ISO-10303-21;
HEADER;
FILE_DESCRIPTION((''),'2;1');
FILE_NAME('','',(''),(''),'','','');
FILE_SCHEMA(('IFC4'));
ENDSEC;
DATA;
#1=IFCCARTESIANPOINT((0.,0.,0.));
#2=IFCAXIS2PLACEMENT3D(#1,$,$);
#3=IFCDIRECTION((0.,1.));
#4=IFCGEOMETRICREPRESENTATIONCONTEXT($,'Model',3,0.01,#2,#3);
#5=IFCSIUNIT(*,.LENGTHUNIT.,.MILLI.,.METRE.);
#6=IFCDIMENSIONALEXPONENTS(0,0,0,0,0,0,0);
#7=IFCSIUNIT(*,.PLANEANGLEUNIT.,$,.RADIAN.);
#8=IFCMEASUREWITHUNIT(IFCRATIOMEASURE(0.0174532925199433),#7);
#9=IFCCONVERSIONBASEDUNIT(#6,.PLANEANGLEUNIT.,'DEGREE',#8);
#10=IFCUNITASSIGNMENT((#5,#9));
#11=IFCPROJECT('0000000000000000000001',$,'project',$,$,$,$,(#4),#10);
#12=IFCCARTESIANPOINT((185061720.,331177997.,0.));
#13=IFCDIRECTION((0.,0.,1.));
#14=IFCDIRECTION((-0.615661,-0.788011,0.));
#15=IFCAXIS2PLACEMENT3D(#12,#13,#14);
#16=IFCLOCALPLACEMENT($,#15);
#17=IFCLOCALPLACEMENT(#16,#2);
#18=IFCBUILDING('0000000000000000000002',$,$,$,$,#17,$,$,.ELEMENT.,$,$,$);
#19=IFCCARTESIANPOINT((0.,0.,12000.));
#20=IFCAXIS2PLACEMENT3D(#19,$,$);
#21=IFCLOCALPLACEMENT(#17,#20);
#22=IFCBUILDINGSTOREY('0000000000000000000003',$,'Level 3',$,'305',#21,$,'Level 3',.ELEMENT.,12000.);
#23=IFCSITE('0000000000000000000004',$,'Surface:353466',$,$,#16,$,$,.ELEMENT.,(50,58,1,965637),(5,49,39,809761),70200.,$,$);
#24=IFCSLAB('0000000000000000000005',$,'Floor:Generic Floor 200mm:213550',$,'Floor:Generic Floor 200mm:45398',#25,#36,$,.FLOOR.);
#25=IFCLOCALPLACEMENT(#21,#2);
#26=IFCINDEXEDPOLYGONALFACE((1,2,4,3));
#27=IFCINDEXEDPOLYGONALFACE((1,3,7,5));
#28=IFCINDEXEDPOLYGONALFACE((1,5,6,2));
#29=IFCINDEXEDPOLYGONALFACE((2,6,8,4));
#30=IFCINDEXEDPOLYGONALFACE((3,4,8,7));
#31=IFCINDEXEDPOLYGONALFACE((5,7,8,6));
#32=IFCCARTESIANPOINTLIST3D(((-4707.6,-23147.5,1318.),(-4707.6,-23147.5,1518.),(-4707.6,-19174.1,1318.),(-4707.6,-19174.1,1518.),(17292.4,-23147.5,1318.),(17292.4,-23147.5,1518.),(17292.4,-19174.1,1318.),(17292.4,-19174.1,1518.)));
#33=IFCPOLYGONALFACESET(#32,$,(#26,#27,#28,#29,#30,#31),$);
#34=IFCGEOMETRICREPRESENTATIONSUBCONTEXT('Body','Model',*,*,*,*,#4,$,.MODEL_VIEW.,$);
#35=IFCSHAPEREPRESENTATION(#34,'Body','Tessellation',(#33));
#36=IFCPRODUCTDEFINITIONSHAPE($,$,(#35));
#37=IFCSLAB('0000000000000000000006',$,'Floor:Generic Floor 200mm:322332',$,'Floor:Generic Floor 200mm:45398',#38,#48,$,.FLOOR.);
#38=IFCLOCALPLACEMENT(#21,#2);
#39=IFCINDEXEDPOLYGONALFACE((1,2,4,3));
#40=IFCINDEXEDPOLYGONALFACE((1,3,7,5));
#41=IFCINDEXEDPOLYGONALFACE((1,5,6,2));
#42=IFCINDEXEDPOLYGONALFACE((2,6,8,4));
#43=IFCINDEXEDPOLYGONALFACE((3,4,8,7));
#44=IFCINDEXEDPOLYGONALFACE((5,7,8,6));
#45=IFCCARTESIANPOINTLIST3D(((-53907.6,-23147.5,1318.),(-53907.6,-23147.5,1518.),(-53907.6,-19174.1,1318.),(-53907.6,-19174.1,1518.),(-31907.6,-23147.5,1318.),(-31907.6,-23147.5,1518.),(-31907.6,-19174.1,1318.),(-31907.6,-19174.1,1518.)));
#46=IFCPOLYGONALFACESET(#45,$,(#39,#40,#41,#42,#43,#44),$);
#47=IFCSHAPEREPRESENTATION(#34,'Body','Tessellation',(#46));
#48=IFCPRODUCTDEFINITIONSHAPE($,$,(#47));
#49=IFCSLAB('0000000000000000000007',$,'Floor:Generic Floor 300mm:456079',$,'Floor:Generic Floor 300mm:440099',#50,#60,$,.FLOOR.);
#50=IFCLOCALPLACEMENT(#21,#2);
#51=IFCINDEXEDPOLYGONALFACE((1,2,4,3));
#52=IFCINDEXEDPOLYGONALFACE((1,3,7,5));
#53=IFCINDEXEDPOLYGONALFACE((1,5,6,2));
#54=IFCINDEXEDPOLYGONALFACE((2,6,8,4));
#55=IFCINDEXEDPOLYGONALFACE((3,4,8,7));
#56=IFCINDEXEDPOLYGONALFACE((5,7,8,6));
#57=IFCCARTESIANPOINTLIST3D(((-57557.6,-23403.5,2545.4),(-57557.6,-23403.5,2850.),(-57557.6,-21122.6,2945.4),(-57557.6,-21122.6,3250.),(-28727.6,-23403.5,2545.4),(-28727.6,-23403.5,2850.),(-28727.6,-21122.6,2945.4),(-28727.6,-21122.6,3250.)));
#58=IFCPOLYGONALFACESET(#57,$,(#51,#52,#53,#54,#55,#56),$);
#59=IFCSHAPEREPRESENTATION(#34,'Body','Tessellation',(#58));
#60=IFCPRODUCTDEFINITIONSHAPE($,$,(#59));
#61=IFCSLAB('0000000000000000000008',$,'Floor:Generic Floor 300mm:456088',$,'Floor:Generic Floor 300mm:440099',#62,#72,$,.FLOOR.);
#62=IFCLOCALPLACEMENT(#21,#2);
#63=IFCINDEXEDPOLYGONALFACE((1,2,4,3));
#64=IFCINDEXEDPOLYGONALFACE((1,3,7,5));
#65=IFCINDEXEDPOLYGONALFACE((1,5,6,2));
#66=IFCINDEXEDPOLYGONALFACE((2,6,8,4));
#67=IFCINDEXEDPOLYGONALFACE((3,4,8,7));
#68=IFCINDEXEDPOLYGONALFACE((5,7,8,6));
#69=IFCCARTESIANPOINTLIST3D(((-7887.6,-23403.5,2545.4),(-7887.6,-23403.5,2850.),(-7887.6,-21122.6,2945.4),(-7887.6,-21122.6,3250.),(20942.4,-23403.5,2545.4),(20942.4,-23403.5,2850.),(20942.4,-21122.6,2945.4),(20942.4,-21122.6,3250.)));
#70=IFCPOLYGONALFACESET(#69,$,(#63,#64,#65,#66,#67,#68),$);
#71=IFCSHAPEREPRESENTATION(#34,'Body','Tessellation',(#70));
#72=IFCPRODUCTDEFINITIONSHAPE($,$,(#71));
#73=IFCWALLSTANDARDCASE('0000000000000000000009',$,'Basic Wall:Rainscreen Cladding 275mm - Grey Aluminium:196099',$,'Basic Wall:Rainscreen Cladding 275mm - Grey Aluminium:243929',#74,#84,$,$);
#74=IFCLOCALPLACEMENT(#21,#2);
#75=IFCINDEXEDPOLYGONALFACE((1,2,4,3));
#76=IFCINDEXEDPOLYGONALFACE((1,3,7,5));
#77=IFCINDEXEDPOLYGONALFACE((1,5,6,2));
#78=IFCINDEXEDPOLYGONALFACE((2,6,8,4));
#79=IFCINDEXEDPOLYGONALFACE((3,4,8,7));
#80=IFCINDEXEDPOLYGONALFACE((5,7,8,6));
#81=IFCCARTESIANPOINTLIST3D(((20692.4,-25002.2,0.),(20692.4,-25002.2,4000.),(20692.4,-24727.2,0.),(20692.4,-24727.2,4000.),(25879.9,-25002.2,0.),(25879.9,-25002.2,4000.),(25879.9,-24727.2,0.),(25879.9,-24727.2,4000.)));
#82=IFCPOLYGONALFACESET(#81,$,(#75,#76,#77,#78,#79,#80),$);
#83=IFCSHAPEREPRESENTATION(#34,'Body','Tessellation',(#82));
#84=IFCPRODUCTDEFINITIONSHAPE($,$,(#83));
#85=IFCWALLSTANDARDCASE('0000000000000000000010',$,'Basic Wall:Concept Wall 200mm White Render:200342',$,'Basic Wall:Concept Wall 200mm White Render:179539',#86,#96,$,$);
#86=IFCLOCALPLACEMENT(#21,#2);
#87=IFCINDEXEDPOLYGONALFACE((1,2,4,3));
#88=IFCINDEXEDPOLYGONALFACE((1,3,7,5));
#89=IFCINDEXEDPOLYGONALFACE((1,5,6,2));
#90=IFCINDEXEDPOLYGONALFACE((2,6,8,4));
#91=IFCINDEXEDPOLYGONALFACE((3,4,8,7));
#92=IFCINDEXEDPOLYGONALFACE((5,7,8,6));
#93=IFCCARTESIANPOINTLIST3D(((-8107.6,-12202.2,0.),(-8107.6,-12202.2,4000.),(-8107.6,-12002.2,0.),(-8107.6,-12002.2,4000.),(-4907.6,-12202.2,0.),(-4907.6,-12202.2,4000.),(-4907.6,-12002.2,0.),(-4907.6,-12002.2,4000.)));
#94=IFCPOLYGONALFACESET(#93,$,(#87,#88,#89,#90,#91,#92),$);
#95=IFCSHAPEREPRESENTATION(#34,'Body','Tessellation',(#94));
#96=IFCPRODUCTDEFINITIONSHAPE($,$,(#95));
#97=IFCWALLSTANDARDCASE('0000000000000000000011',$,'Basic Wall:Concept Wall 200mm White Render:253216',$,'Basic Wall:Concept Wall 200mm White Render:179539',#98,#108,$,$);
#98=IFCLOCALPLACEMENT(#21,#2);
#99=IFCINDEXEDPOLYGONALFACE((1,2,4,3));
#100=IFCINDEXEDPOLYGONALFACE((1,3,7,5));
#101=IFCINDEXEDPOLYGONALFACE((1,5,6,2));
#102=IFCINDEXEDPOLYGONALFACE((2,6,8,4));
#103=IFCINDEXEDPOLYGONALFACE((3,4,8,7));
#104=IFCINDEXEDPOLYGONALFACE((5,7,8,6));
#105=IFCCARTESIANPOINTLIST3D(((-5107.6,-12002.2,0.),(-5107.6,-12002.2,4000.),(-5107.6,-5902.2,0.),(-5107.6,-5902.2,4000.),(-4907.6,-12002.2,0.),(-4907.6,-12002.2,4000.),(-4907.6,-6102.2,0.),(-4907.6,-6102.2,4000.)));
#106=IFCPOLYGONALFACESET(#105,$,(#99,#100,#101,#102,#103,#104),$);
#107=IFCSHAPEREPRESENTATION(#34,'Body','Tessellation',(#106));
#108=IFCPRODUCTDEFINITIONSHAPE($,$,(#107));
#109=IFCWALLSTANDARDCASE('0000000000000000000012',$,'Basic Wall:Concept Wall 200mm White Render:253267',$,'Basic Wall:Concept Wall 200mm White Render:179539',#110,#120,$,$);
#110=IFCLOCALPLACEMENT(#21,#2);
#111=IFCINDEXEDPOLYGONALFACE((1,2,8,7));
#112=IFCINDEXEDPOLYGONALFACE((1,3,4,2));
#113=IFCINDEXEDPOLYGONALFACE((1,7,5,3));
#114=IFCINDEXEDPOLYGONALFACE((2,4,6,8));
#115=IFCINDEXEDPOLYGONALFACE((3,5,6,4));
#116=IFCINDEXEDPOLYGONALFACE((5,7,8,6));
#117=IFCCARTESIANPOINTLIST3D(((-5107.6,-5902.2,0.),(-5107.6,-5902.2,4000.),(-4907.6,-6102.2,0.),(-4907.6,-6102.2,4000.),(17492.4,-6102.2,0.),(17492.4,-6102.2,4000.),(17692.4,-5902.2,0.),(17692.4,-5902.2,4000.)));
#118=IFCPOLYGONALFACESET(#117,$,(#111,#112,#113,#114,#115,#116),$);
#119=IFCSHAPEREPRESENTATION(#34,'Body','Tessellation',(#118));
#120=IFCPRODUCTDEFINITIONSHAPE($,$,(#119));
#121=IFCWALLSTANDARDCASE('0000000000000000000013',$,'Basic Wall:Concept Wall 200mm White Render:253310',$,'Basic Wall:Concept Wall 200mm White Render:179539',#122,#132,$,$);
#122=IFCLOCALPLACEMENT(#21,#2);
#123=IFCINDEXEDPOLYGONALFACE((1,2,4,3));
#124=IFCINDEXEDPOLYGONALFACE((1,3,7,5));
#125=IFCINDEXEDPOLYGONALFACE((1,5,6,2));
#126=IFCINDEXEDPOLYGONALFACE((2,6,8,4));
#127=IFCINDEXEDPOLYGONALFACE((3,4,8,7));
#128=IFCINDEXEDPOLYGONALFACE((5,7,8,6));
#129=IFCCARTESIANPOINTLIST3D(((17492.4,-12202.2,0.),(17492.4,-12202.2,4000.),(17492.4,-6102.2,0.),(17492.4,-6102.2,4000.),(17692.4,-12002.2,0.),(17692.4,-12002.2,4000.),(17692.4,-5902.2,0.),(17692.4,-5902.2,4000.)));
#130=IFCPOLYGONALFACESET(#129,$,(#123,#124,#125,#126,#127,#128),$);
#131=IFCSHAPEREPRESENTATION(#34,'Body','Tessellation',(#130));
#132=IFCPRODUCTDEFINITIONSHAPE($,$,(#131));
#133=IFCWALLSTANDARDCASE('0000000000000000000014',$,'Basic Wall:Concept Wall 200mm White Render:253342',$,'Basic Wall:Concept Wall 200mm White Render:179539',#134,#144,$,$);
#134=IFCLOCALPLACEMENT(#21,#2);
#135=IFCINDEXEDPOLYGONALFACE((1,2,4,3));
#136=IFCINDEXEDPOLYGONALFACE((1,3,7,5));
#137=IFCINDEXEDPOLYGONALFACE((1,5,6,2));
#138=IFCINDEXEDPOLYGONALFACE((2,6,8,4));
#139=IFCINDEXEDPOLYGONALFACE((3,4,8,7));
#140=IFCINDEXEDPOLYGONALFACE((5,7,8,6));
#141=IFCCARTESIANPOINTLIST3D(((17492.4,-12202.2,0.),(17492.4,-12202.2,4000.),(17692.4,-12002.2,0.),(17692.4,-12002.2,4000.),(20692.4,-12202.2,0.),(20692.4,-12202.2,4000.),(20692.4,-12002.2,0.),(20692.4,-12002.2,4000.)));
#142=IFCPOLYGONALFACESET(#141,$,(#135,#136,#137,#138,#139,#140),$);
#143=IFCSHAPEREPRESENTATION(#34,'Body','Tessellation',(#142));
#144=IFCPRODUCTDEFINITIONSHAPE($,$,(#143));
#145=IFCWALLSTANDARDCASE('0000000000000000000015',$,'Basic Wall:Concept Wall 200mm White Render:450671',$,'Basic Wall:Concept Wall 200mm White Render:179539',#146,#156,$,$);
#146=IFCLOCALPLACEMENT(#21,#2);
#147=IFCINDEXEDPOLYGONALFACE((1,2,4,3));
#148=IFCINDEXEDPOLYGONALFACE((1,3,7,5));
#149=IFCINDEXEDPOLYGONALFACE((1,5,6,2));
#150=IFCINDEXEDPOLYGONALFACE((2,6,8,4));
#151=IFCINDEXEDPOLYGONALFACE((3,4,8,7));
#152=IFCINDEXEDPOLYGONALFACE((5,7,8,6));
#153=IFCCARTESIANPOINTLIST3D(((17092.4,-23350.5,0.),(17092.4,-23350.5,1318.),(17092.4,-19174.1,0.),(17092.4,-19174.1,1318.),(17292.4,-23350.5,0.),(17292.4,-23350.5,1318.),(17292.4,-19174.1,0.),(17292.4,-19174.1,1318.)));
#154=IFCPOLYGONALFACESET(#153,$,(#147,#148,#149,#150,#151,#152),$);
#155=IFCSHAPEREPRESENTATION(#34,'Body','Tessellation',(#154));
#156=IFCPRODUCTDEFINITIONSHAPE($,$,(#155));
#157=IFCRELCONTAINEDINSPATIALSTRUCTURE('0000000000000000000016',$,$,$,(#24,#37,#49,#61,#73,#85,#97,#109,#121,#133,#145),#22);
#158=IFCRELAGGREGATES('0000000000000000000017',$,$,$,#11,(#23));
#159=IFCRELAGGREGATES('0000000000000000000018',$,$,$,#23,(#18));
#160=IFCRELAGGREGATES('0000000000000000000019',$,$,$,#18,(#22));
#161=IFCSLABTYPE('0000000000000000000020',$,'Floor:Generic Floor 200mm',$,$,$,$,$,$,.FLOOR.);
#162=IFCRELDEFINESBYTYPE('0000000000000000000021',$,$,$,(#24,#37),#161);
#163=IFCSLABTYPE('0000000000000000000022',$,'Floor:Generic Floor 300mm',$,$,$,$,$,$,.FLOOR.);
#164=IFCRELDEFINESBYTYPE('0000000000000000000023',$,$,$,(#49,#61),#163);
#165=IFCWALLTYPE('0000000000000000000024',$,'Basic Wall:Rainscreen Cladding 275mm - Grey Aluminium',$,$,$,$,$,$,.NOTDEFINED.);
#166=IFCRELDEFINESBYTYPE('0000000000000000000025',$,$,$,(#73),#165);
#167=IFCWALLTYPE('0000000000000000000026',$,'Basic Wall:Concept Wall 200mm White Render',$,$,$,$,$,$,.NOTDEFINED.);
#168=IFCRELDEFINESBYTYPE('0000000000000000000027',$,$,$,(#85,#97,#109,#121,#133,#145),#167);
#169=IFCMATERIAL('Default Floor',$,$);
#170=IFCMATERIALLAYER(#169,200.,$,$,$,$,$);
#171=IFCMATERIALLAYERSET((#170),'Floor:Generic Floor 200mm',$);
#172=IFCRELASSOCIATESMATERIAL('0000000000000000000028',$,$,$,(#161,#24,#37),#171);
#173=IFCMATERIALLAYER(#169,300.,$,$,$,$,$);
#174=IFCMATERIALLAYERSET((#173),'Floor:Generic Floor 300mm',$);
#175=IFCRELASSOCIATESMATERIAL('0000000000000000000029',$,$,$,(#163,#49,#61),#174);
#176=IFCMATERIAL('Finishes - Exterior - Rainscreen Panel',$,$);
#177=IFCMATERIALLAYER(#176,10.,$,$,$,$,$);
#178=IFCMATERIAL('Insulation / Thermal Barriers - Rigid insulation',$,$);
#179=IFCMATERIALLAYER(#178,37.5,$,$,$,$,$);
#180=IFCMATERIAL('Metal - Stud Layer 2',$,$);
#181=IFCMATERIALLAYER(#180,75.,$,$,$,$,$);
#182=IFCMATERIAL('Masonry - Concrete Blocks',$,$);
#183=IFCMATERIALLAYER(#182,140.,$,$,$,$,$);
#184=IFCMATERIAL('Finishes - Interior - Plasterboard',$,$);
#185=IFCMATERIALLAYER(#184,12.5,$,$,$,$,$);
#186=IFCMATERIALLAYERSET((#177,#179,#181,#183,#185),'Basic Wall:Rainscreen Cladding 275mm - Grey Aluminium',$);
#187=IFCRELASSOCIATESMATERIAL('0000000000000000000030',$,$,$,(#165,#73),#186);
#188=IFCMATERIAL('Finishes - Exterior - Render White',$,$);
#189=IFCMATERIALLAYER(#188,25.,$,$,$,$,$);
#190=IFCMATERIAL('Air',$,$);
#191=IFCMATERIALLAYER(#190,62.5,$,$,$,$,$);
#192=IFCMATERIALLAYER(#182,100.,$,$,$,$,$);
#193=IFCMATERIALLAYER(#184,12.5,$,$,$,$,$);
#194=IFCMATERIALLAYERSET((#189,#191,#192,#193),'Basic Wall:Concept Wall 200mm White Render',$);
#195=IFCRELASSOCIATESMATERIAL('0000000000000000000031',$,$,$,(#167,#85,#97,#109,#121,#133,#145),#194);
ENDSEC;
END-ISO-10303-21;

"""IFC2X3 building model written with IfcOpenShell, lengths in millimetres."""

from ifc_helpers import new_model, entity, si_unit, converted_unit, direction, frame, frame_2d, origin, origin_2d_with_axis, place, context, subcontext, project, spatial, polyline, rectangle, outline, extrude, clip, halfspace, material, layer, layer_set, layer_usage, type_object, element, save


model = new_model("IFC2X3")

# Units and contexts
model_context = context("Model", 3, precision=0.01, world=origin(), true_north=direction((0.0, 1.0)))
body_context = subcontext(model_context, "Body", "Model", "MODEL_VIEW")
ifc_project = project(units=[si_unit("LENGTHUNIT", "METRE", prefix="MILLI"), converted_unit("PLANEANGLEUNIT", "DEGREE", entity("IfcRatioMeasure", 0.0174532925199433), si_unit("PLANEANGLEUNIT", "RADIAN"), dimensions=[0, 0, 0, 0, 0, 0, 0])], contexts=[model_context])

# Site, building, storey
site_placement = place(None, frame((185061720.0, 331177997.0, 0.0), z_axis=(0.0, 0.0, 1.0), x_axis=(-0.615661, -0.788011, 0.0)))
site = spatial("IfcSite", under=ifc_project, at=site_placement, Name="Surface:353466", CompositionType="ELEMENT", RefLatitude=(50, 58, 1, 965637), RefLongitude=(5, 49, 39, 809761), RefElevation=70200.0)
building_placement = place(site_placement, origin())
building = spatial("IfcBuilding", under=site, at=building_placement, CompositionType="ELEMENT")
storey_placement = place(building_placement, frame((0.0, 0.0, 12000.0)))
storey = spatial("IfcBuildingStorey", under=building, at=storey_placement, Name="Level 3", ObjectType="305", LongName="Level 3", CompositionType="ELEMENT", Elevation=12000.0)

# Slabs
ifc_material_1 = material(Name="Default Floor")
ifc_layer_1 = layer(ifc_material_1, 200.0)
ifc_layer_set_1 = layer_set([ifc_layer_1], Name="Floor:Generic Floor 200mm")
ifc_layer_usage_1 = layer_usage(ifc_layer_set_1, "AXIS3", "POSITIVE", 0.0)
slab_type_1 = type_object("IfcSlabType", Name="Floor:Generic Floor 200mm", PredefinedType="FLOOR", material=ifc_layer_set_1)
slab_1_placement = place(storey_placement, origin())
element("IfcSlab", 1, at=slab_1_placement, inside=storey, type_object=slab_type_1, material=ifc_layer_usage_1, Name="Floor:Generic Floor 200mm:213550", ObjectType="Floor:Generic Floor 200mm:45398", PredefinedType="FLOOR", context=body_context, shape_type="SweptSolid", body=[
    extrude(rectangle(XDim=3973.3, YDim=22000.0, at=frame_2d((0.0, 0.0), x_axis=(1.0, 0.0))), frame((6292.4, -21160.8, 1518.0), z_axis=(0.0, 0.0, -1.0), x_axis=(0.0, 1.0, 0.0)), (0.0, 0.0, 1.0), 200.0),
])
ifc_layer_usage_2 = layer_usage(ifc_layer_set_1, "AXIS3", "POSITIVE", 0.0)
slab_2_placement = place(storey_placement, origin())
element("IfcSlab", 2, at=slab_2_placement, inside=storey, type_object=slab_type_1, material=ifc_layer_usage_2, Name="Floor:Generic Floor 200mm:322332", ObjectType="Floor:Generic Floor 200mm:45398", PredefinedType="FLOOR", context=body_context, shape_type="SweptSolid", body=[
    extrude(rectangle(XDim=3973.3, YDim=22000.0, at=frame_2d((0.0, 0.0), x_axis=(1.0, 0.0))), frame((-42907.6, -21160.8, 1518.0), z_axis=(0.0, 0.0, -1.0), x_axis=(0.0, 1.0, 0.0)), (0.0, 0.0, 1.0), 200.0),
])
ifc_layer_2 = layer(ifc_material_1, 300.0)
ifc_layer_set_2 = layer_set([ifc_layer_2], Name="Floor:Generic Floor 300mm")
slab_type_2 = type_object("IfcSlabType", Name="Floor:Generic Floor 300mm", PredefinedType="FLOOR", material=ifc_layer_set_2)
ifc_layer_usage_3 = layer_usage(ifc_layer_set_2, "AXIS3", "POSITIVE", 0.0)
slab_3_placement = place(storey_placement, origin())
element("IfcSlab", 3, at=slab_3_placement, inside=storey, type_object=slab_type_2, material=ifc_layer_usage_3, Name="Floor:Generic Floor 300mm:456079", ObjectType="Floor:Generic Floor 300mm:440099", PredefinedType="FLOOR", context=body_context, shape_type="Clipping", body=[
    clip(clip(extrude(rectangle(XDim=2315.6, YDim=28830.0, at=frame_2d((0.0, 0.0), x_axis=(1.0, 0.0))), frame((-43142.6, -22263.0, 3050.0), z_axis=(0.0, 0.172739, -0.984968), x_axis=(0.0, 0.984968, 0.172739)), (-0.172739, 0.0, 0.984968), 309.2), halfspace(frame((-43142.6, -21122.6, 2945.4), z_axis=(0.0, 0.172739, -0.984968), x_axis=(0.0, -0.984968, -0.172739)), False)), halfspace(frame((-43142.6, -21122.6, 3250.0), z_axis=(0.0, -0.172739, 0.984968), x_axis=(0.0, 0.984968, 0.172739)), False)),
])
ifc_layer_usage_4 = layer_usage(ifc_layer_set_2, "AXIS3", "POSITIVE", 0.0)
slab_4_placement = place(storey_placement, origin())
element("IfcSlab", 4, at=slab_4_placement, inside=storey, type_object=slab_type_2, material=ifc_layer_usage_4, Name="Floor:Generic Floor 300mm:456088", ObjectType="Floor:Generic Floor 300mm:440099", PredefinedType="FLOOR", context=body_context, shape_type="Clipping", body=[
    clip(clip(extrude(rectangle(XDim=2315.6, YDim=28830.0, at=origin_2d_with_axis()), frame((6527.4, -22263.0, 3050.0), z_axis=(0.0, 0.172739, -0.984968), x_axis=(0.0, 0.984968, 0.172739)), (-0.172739, 0.0, 0.984968), 309.2), halfspace(frame((6527.4, -21122.6, 2945.4), z_axis=(0.0, 0.172739, -0.984968), x_axis=(0.0, -0.984968, -0.172739)), False)), halfspace(frame((6527.4, -21122.6, 3250.0), z_axis=(0.0, -0.172739, 0.984968), x_axis=(0.0, 0.984968, 0.172739)), False)),
])

# Walls
ifc_material_2 = material(Name="Finishes - Exterior - Rainscreen Panel")
ifc_layer_3 = layer(ifc_material_2, 10.0)
ifc_material_3 = material(Name="Insulation / Thermal Barriers - Rigid insulation")
ifc_layer_4 = layer(ifc_material_3, 37.5)
ifc_material_4 = material(Name="Metal - Stud Layer 2")
ifc_layer_5 = layer(ifc_material_4, 75.0)
ifc_material_5 = material(Name="Masonry - Concrete Blocks")
ifc_layer_6 = layer(ifc_material_5, 140.0)
ifc_material_6 = material(Name="Finishes - Interior - Plasterboard")
ifc_layer_7 = layer(ifc_material_6, 12.5)
ifc_layer_set_3 = layer_set([ifc_layer_3, ifc_layer_4, ifc_layer_5, ifc_layer_6, ifc_layer_7], Name="Basic Wall:Rainscreen Cladding 275mm - Grey Aluminium")
ifc_layer_usage_5 = layer_usage(ifc_layer_set_3, "AXIS2", "POSITIVE", -137.5)
wall_type_1 = type_object("IfcWallType", Name="Basic Wall:Rainscreen Cladding 275mm - Grey Aluminium", PredefinedType="NOTDEFINED", material=ifc_layer_set_3)
wall_1_placement = place(storey_placement, frame((20692.4, -24864.7, 0.0)))
element("IfcWallStandardCase", 5, at=wall_1_placement, inside=storey, type_object=wall_type_1, material=ifc_layer_usage_5, Name="Basic Wall:Rainscreen Cladding 275mm - Grey Aluminium:196099", ObjectType="Basic Wall:Rainscreen Cladding 275mm - Grey Aluminium:243929", context=body_context, shape_type="Clipping", body=[
    clip(extrude(rectangle(XDim=5187.5, YDim=275.0, at=frame_2d((2593.8, 0.0), x_axis=(-1.0, 0.0))), origin(), (0.0, 0.0, 1.0), 4000.0), halfspace(frame((0.0, 0.0, -12000.0)), True)),
])
ifc_material_7 = material(Name="Finishes - Exterior - Render White")
ifc_layer_8 = layer(ifc_material_7, 25.0)
ifc_material_8 = material(Name="Air")
ifc_layer_9 = layer(ifc_material_8, 62.5)
ifc_layer_10 = layer(ifc_material_5, 100.0)
ifc_layer_11 = layer(ifc_material_6, 12.5)
ifc_layer_set_4 = layer_set([ifc_layer_8, ifc_layer_9, ifc_layer_10, ifc_layer_11], Name="Basic Wall:Concept Wall 200mm White Render")
ifc_layer_usage_6 = layer_usage(ifc_layer_set_4, "AXIS2", "NEGATIVE", 100.0)
wall_type_2 = type_object("IfcWallType", Name="Basic Wall:Concept Wall 200mm White Render", PredefinedType="NOTDEFINED", material=ifc_layer_set_4)
wall_2_placement = place(storey_placement, frame((-8107.6, -12102.2, 0.0)))
element("IfcWallStandardCase", 6, at=wall_2_placement, inside=storey, type_object=wall_type_2, material=ifc_layer_usage_6, Name="Basic Wall:Concept Wall 200mm White Render:200342", ObjectType="Basic Wall:Concept Wall 200mm White Render:179539", context=body_context, shape_type="Clipping", body=[
    clip(extrude(rectangle(XDim=3200.0, YDim=200.0, at=frame_2d((1600.0, 0.0), x_axis=(-1.0, 0.0))), origin(), (0.0, 0.0, 1.0), 4000.0), halfspace(frame((0.0, 0.0, -12000.0)), True)),
])
ifc_layer_usage_7 = layer_usage(ifc_layer_set_4, "AXIS2", "NEGATIVE", 100.0)
wall_3_placement = place(storey_placement, frame((-5007.6, -12002.2, 0.0), z_axis=(0.0, 0.0, 1.0), x_axis=(0.0, 1.0, 0.0)))
element("IfcWallStandardCase", 7, at=wall_3_placement, inside=storey, type_object=wall_type_2, material=ifc_layer_usage_7, Name="Basic Wall:Concept Wall 200mm White Render:253216", ObjectType="Basic Wall:Concept Wall 200mm White Render:179539", context=body_context, shape_type="Clipping", body=[
    clip(extrude(outline(polyline([(5900.0, -100.0), (6100.0, 100.0), (0.0, 100.0), (0.0, -100.0), (5900.0, -100.0)])), origin(), (0.0, 0.0, 1.0), 4000.0), halfspace(frame((0.0, 0.0, -12000.0)), True)),
])
ifc_layer_usage_8 = layer_usage(ifc_layer_set_4, "AXIS2", "NEGATIVE", 100.0)
wall_4_placement = place(storey_placement, frame((-5107.6, -6002.2, 0.0)))
element("IfcWallStandardCase", 8, at=wall_4_placement, inside=storey, type_object=wall_type_2, material=ifc_layer_usage_8, Name="Basic Wall:Concept Wall 200mm White Render:253267", ObjectType="Basic Wall:Concept Wall 200mm White Render:179539", context=body_context, shape_type="Clipping", body=[
    clip(extrude(outline(polyline([(200.0, -100.0), (22600.0, -100.0), (22800.0, 100.0), (0.0, 100.0), (200.0, -100.0)])), origin(), (0.0, 0.0, 1.0), 4000.0), halfspace(frame((0.0, 0.0, -12000.0)), True)),
])
ifc_layer_usage_9 = layer_usage(ifc_layer_set_4, "AXIS2", "NEGATIVE", 100.0)
wall_5_placement = place(storey_placement, frame((17592.4, -5902.2, 0.0), z_axis=(0.0, 0.0, 1.0), x_axis=(0.0, -1.0, 0.0)))
element("IfcWallStandardCase", 9, at=wall_5_placement, inside=storey, type_object=wall_type_2, material=ifc_layer_usage_9, Name="Basic Wall:Concept Wall 200mm White Render:253310", ObjectType="Basic Wall:Concept Wall 200mm White Render:179539", context=body_context, shape_type="Clipping", body=[
    clip(extrude(outline(polyline([(6300.0, -100.0), (6100.0, 100.0), (0.0, 100.0), (200.0, -100.0), (6300.0, -100.0)])), origin(), (0.0, 0.0, 1.0), 4000.0), halfspace(frame((0.0, 0.0, -12000.0)), True)),
])
ifc_layer_usage_10 = layer_usage(ifc_layer_set_4, "AXIS2", "NEGATIVE", 100.0)
wall_6_placement = place(storey_placement, frame((17492.4, -12102.2, 0.0)))
element("IfcWallStandardCase", 10, at=wall_6_placement, inside=storey, type_object=wall_type_2, material=ifc_layer_usage_10, Name="Basic Wall:Concept Wall 200mm White Render:253342", ObjectType="Basic Wall:Concept Wall 200mm White Render:179539", context=body_context, shape_type="Clipping", body=[
    clip(extrude(outline(polyline([(0.0, -100.0), (3200.0, -100.0), (3200.0, 100.0), (200.0, 100.0), (0.0, -100.0)])), origin(), (0.0, 0.0, 1.0), 4000.0), halfspace(frame((0.0, 0.0, -12000.0)), True)),
])
ifc_layer_usage_11 = layer_usage(ifc_layer_set_4, "AXIS2", "NEGATIVE", 100.0)
wall_7_placement = place(storey_placement, frame((17192.4, -23350.5, 0.0), z_axis=(0.0, 0.0, 1.0), x_axis=(0.0, 1.0, 0.0)))
element("IfcWallStandardCase", 11, at=wall_7_placement, inside=storey, type_object=wall_type_2, material=ifc_layer_usage_11, Name="Basic Wall:Concept Wall 200mm White Render:450671", ObjectType="Basic Wall:Concept Wall 200mm White Render:179539", context=body_context, shape_type="Clipping", body=[
    clip(extrude(rectangle(XDim=4176.4, YDim=200.0, at=frame_2d((2088.2, 0.0), x_axis=(-1.0, 0.0))), origin(), (0.0, 0.0, 1.0), 1318.0), halfspace(frame((0.0, 0.0, -8000.0)), True)),
])

save(model, "model.ifc")
